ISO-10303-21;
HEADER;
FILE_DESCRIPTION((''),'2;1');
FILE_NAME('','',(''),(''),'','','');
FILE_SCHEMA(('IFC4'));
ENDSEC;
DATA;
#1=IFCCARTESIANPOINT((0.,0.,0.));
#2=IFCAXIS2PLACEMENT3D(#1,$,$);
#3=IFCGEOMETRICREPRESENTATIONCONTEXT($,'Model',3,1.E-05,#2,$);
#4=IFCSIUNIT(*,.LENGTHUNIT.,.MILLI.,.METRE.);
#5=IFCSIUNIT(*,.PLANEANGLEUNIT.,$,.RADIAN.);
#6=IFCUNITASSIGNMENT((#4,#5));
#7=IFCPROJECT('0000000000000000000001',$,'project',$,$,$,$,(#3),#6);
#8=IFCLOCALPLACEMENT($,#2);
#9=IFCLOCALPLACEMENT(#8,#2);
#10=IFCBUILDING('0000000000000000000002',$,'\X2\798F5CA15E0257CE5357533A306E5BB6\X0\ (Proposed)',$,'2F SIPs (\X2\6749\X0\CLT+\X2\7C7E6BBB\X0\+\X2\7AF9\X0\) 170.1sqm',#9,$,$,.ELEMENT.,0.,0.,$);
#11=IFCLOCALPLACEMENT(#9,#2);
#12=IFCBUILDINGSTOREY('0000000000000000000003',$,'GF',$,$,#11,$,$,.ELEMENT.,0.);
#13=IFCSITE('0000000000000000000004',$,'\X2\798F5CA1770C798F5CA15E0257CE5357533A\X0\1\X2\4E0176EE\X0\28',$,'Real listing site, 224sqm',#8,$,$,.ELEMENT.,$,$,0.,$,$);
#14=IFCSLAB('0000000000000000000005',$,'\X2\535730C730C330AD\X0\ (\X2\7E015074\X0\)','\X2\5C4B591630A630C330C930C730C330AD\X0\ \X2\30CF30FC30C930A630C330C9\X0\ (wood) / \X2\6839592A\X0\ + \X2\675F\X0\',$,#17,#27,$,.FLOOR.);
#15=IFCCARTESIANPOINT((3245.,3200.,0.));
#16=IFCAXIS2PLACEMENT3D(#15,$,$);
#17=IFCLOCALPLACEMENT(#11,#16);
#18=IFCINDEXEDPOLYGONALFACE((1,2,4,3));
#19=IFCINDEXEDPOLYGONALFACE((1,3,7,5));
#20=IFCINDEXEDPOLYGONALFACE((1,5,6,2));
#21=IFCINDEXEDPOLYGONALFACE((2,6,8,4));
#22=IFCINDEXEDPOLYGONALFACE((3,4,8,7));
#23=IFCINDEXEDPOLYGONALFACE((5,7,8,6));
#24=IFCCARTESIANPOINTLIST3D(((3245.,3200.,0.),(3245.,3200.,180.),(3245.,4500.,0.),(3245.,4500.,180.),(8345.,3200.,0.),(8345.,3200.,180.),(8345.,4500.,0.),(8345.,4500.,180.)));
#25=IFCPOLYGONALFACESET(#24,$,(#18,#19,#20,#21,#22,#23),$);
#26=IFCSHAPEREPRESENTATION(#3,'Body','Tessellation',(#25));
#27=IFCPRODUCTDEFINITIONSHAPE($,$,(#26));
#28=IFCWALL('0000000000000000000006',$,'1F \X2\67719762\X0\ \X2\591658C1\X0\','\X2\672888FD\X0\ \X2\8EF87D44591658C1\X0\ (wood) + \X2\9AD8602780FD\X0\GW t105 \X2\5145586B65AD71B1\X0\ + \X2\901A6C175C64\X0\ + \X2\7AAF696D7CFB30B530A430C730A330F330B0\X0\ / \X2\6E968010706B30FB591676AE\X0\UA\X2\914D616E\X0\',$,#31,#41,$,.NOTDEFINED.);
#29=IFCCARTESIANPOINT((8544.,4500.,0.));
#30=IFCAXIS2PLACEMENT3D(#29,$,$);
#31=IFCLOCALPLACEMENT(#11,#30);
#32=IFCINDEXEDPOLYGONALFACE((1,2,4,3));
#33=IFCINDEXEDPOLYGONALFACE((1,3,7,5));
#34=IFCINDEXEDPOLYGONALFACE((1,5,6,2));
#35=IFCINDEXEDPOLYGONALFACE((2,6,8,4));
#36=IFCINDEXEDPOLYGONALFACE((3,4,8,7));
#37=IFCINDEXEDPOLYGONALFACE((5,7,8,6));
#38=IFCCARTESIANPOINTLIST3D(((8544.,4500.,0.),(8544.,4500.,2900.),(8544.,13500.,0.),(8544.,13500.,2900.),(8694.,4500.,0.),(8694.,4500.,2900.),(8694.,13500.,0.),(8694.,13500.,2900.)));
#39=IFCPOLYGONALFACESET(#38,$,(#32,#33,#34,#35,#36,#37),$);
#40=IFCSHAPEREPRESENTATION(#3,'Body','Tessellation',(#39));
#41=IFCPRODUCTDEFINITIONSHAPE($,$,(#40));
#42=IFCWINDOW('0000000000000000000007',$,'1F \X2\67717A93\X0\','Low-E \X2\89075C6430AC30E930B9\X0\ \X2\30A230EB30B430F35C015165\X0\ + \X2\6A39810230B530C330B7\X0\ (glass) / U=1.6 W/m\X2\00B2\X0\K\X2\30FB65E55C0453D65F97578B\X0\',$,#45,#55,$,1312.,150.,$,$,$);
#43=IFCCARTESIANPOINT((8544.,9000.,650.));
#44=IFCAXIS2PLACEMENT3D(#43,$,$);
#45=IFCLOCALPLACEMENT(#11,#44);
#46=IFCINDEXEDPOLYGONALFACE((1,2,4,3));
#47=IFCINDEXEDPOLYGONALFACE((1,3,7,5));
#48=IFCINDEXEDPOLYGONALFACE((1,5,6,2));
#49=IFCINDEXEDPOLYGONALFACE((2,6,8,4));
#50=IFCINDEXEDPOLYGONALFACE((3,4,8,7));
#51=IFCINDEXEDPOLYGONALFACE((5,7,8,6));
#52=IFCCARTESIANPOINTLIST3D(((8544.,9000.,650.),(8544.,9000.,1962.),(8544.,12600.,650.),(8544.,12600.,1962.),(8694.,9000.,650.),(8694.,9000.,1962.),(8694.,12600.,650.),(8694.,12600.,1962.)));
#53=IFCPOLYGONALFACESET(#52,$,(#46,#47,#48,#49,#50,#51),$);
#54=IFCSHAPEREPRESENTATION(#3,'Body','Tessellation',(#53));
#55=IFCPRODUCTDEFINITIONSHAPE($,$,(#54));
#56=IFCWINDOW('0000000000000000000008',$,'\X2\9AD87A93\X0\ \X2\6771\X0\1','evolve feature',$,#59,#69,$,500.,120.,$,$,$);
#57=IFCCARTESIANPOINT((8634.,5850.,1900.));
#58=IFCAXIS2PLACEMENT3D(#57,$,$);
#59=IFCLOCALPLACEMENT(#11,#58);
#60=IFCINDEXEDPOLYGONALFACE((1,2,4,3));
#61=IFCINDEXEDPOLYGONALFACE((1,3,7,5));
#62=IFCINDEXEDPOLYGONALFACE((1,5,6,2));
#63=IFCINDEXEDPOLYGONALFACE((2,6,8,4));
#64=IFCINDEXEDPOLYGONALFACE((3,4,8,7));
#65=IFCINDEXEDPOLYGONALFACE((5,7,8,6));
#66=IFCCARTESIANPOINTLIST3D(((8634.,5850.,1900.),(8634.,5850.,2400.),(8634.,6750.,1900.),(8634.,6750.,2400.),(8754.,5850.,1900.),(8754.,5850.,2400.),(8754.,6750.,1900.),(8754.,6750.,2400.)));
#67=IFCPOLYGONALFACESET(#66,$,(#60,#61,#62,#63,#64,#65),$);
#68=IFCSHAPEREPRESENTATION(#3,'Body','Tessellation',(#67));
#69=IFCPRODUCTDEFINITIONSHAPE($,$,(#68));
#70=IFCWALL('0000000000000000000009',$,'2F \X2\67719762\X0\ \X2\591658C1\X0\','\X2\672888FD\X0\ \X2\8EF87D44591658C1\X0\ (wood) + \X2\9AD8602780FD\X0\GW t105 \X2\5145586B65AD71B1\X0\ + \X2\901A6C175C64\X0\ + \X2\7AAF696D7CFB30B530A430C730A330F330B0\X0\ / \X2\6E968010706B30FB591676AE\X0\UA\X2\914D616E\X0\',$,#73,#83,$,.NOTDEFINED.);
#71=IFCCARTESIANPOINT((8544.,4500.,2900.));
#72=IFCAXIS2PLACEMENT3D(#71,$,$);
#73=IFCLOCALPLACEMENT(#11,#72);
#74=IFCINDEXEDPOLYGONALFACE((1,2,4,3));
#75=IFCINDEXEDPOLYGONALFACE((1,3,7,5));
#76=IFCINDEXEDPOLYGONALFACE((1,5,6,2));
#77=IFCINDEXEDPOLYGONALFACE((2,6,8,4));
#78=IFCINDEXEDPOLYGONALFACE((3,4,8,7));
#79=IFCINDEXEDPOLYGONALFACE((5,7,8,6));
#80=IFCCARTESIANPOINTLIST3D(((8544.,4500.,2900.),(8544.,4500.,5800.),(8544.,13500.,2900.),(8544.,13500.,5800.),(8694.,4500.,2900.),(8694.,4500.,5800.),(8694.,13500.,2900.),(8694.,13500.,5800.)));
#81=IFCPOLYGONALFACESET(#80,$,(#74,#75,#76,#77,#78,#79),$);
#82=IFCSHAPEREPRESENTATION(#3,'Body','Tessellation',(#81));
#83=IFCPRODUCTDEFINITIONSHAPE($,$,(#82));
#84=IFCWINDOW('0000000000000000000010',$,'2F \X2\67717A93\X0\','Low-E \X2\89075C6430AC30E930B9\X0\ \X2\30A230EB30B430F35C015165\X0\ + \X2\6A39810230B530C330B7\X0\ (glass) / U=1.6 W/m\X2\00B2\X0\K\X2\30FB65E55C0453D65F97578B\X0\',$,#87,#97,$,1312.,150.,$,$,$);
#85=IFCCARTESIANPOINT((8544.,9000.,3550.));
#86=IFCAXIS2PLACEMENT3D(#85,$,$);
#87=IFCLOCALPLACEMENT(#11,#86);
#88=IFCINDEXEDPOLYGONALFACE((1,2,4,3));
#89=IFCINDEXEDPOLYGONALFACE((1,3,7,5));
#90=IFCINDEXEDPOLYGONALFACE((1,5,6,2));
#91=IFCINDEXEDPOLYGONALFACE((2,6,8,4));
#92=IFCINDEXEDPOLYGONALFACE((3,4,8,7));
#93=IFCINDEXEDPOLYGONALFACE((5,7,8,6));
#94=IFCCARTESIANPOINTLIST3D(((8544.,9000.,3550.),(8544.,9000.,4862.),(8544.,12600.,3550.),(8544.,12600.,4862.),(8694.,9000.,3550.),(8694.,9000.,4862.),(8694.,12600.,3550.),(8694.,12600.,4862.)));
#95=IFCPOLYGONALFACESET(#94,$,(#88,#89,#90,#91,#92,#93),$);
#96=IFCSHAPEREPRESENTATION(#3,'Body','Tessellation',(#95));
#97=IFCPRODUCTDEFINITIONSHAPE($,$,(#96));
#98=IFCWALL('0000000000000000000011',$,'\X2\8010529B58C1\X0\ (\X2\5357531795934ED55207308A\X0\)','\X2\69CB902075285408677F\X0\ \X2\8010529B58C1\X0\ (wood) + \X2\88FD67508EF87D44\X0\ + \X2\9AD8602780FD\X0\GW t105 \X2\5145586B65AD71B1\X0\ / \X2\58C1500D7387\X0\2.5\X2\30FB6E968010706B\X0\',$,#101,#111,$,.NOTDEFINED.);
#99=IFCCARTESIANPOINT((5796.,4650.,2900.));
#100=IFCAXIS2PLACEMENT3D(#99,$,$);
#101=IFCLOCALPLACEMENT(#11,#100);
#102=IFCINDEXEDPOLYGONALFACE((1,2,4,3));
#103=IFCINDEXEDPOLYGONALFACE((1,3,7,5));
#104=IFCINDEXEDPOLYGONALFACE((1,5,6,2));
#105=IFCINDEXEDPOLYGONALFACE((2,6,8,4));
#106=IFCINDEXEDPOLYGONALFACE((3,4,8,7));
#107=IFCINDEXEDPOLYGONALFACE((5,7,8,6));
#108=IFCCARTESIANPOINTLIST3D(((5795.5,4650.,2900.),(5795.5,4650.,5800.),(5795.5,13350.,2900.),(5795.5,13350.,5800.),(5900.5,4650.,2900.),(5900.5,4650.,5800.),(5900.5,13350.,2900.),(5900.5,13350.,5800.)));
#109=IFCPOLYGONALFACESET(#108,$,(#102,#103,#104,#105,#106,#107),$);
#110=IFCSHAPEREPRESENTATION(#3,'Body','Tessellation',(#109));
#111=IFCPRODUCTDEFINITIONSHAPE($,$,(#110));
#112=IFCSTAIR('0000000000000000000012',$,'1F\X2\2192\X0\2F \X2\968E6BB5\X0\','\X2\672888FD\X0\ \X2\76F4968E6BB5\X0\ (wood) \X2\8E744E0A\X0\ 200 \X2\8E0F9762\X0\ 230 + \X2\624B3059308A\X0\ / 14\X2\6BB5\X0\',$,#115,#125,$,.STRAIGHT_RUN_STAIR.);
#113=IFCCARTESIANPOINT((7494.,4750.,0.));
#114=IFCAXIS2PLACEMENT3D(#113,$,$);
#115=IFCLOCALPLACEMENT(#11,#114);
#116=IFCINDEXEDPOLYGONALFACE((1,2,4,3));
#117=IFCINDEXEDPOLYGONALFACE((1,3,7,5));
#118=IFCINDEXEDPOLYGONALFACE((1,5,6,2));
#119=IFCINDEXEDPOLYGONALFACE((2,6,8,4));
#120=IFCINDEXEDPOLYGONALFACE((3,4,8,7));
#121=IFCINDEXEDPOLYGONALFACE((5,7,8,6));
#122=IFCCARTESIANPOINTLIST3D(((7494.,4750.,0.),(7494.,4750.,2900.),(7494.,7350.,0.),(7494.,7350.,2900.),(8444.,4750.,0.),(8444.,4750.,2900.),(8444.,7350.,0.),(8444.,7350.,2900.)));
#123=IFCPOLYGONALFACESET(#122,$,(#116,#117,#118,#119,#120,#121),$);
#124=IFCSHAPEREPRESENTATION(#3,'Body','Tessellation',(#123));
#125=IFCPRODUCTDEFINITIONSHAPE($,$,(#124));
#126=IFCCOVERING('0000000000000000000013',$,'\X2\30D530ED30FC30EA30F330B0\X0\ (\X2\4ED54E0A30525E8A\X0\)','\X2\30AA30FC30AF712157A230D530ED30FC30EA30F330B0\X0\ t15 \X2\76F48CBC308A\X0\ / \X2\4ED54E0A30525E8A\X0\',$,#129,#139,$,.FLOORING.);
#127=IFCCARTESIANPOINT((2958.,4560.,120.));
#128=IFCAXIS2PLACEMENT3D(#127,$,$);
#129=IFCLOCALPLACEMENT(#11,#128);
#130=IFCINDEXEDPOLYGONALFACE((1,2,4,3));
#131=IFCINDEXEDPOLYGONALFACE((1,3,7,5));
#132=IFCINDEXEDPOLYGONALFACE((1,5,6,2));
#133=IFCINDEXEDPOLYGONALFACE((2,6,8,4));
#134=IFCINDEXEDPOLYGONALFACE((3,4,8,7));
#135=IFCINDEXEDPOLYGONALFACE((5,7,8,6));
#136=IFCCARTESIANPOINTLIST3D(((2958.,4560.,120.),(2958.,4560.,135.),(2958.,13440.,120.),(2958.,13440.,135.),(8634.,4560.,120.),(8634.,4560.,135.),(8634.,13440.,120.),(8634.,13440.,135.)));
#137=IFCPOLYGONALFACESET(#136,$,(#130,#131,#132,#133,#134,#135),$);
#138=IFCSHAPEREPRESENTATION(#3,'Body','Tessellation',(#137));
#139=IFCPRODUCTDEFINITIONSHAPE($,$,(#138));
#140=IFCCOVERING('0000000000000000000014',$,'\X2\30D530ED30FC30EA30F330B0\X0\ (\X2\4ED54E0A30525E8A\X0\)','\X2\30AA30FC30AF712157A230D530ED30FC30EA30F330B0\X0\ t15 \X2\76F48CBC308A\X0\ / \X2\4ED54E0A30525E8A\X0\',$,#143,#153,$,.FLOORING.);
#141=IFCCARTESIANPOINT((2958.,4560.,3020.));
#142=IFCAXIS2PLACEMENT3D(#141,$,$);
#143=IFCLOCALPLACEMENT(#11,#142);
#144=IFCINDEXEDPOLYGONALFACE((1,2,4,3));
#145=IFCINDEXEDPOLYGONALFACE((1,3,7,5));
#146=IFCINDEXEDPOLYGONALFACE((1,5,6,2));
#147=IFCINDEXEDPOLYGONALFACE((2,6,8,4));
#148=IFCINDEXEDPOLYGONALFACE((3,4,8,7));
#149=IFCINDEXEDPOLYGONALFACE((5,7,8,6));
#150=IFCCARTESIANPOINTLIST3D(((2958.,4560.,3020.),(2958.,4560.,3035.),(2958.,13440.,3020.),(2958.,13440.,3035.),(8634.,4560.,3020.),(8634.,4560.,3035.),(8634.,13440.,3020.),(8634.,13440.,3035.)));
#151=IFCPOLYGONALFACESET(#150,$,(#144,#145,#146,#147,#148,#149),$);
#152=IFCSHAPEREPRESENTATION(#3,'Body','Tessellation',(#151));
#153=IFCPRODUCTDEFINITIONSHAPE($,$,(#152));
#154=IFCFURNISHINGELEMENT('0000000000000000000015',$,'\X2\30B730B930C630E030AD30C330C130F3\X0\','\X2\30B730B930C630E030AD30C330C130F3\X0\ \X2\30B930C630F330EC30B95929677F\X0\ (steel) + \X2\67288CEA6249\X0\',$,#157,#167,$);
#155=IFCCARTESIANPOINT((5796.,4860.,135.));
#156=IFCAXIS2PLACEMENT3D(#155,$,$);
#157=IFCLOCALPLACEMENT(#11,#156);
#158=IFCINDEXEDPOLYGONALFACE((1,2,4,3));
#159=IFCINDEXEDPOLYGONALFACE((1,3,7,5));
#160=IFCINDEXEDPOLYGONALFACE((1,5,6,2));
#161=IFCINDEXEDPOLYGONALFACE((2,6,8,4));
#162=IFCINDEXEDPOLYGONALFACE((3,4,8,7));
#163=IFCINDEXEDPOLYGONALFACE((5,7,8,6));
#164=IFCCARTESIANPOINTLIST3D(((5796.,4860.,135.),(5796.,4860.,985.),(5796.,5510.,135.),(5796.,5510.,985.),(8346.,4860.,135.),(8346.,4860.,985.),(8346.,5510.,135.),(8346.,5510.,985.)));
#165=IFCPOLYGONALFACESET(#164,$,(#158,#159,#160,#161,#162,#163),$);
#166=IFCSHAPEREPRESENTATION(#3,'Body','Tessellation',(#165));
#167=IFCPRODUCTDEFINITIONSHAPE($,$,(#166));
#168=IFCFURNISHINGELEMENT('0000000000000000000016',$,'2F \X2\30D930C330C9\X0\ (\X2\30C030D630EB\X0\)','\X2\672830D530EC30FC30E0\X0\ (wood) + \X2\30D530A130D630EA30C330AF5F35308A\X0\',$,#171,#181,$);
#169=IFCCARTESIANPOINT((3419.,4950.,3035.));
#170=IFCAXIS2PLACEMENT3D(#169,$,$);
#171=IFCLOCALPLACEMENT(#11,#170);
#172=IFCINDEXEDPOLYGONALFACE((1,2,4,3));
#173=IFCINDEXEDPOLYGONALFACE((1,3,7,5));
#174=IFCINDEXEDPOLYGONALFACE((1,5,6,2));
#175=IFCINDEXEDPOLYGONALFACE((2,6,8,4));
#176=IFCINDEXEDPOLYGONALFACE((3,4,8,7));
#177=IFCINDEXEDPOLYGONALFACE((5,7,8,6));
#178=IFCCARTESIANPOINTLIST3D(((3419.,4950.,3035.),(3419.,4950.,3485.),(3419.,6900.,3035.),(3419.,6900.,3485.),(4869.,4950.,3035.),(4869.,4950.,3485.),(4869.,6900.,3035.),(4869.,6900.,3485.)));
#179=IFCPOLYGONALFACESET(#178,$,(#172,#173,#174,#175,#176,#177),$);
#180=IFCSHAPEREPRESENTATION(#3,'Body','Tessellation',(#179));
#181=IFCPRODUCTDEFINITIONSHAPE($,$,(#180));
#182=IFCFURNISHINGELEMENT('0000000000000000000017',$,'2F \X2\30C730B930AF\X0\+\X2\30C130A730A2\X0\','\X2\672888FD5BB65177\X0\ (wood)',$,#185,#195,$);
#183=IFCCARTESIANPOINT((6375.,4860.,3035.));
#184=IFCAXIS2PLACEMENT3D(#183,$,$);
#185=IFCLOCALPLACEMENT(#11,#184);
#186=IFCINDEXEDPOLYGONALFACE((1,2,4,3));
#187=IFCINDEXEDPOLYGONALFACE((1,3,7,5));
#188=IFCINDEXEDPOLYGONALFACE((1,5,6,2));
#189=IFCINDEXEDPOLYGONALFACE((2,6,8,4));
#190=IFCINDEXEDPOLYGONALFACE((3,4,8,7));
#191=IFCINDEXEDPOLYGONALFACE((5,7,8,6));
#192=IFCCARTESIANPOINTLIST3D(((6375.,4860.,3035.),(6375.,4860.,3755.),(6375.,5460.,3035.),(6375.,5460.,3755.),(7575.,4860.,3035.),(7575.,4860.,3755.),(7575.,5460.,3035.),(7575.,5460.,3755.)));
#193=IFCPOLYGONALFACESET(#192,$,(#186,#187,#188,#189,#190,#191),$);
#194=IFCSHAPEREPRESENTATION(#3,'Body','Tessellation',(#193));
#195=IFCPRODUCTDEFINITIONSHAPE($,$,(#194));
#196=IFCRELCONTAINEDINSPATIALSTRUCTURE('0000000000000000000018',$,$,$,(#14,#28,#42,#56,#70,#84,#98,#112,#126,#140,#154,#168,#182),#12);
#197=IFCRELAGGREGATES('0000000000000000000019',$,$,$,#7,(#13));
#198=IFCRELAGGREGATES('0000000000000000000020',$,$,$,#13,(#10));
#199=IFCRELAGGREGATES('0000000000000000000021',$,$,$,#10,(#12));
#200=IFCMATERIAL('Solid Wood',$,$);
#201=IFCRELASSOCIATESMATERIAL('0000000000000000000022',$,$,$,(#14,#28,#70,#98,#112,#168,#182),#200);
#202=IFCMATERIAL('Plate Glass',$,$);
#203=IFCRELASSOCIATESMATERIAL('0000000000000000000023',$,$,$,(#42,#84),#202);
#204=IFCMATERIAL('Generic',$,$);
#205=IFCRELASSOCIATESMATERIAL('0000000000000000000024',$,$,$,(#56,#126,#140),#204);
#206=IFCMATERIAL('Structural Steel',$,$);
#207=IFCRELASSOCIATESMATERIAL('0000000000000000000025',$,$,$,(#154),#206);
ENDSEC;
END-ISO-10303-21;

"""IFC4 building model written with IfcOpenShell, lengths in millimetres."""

from ifc_helpers import new_model, si_unit, frame, frame_2d, origin, place, context, project, spatial, rectangle, extrude, material, element, fill, save


model = new_model("IFC4")

# Units and contexts
model_context = context("Model", 3, precision=1e-05, world=origin())
ifc_project = project(units=[si_unit("LENGTHUNIT", "METRE", prefix="MILLI"), si_unit("PLANEANGLEUNIT", "RADIAN")], contexts=[model_context])

# Site, building, storey
site_placement = place(None, origin())
site = spatial("IfcSite", under=ifc_project, at=site_placement, Name="福岡県福岡市城南区1丁目28", ObjectType="Real listing site, 224sqm", CompositionType="ELEMENT", RefElevation=0.0)
building_placement = place(site_placement, origin())
building = spatial("IfcBuilding", under=site, at=building_placement, Name="福岡市城南区の家 (Proposed)", ObjectType="2F SIPs (杉CLT+籾殻+竹) 170.1sqm", CompositionType="ELEMENT", ElevationOfRefHeight=0.0, ElevationOfTerrain=0.0)
storey_placement = place(building_placement, origin())
storey = spatial("IfcBuildingStorey", under=building, at=storey_placement, Name="GF", CompositionType="ELEMENT", Elevation=0.0)

# Slab
ifc_material_1 = material(Name="Solid Wood")
slab_placement = place(storey_placement, frame((3245.0, 3200.0, 0.0)))
element("IfcSlab", 1, at=slab_placement, inside=storey, material=ifc_material_1, Name="南デッキ (縁側)", Description="屋外ウッドデッキ ハードウッド (wood) / 根太 + 束", PredefinedType="FLOOR", context=model_context, shape_type="SweptSolid", body=[
    extrude(rectangle(XDim=5100.0, YDim=1300.0, at=frame_2d((2550.0, 650.0))), frame((3245.0, 3200.0, 0.0)), (0.0, 0.0, 1.0), 180.0),
])

# Wall, openings, windows
wall_1_placement = place(storey_placement, frame((8544.0, 4500.0, 0.0)))
wall_1 = element("IfcWall", 2, at=wall_1_placement, inside=storey, material=ifc_material_1, Name="1F 東面 外壁", Description="木製 軸組外壁 (wood) + 高性能GW t105 充填断熱 + 通気層 + 窯業系サイディング / 準耐火・外皮UA配慮", PredefinedType="NOTDEFINED", context=model_context, shape_type="SweptSolid", body=[
    extrude(rectangle(XDim=150.0, YDim=9000.0, at=frame_2d((75.0, 4500.0))), frame((8544.0, 4500.0, 0.0)), (0.0, 0.0, 1.0), 2900.0),
])
opening_1_placement = place(storey_placement, frame((8544.0, 9000.0, 650.0)))
opening_1 = element("IfcOpeningElement", 3, at=opening_1_placement, cuts=wall_1, PredefinedType="NOTDEFINED", context=model_context, shape_type="SweptSolid", body=[
    extrude(rectangle(XDim=150.0, YDim=3600.0, at=frame_2d((75.0, 1800.0))), frame((8544.0, 9000.0, 650.0)), (0.0, 0.0, 1.0), 1312.0),
])
opening_2_placement = place(storey_placement, frame((8634.0, 5850.0, 1900.0)))
opening_2 = element("IfcOpeningElement", 4, at=opening_2_placement, cuts=wall_1, PredefinedType="NOTDEFINED", context=model_context, shape_type="SweptSolid", body=[
    extrude(rectangle(XDim=120.0, YDim=900.0, at=frame_2d((60.0, 450.0))), frame((8634.0, 5850.0, 1900.0)), (0.0, 0.0, 1.0), 500.0),
])
ifc_material_2 = material(Name="Plate Glass")
window_1_placement = place(storey_placement, frame((8544.0, 9000.0, 650.0)))
window_1 = element("IfcWindow", 5, at=window_1_placement, inside=storey, material=ifc_material_2, Name="1F 東窓", Description="Low-E 複層ガラス アルゴン封入 + 樹脂サッシ (glass) / U=1.6 W/m²K・日射取得型", OverallHeight=1312.0, OverallWidth=150.0, context=model_context, shape_type="SweptSolid", body=[
    extrude(rectangle(XDim=150.0, YDim=3600.0, at=frame_2d((75.0, 1800.0))), frame((8544.0, 9000.0, 650.0)), (0.0, 0.0, 1.0), 1312.0),
])
fill(opening_1, window_1)
ifc_material_3 = material(Name="Generic")
window_2_placement = place(storey_placement, frame((8634.0, 5850.0, 1900.0)))
window_2 = element("IfcWindow", 6, at=window_2_placement, inside=storey, material=ifc_material_3, Name="高窓 東1", Description="evolve feature", OverallHeight=500.0, OverallWidth=120.0, context=model_context, shape_type="SweptSolid", body=[
    extrude(rectangle(XDim=120.0, YDim=900.0, at=frame_2d((60.0, 450.0))), frame((8634.0, 5850.0, 1900.0)), (0.0, 0.0, 1.0), 500.0),
])
fill(opening_2, window_2)

# Wall, opening, window
wall_2_placement = place(storey_placement, frame((8544.0, 4500.0, 2900.0)))
wall_2 = element("IfcWall", 7, at=wall_2_placement, inside=storey, material=ifc_material_1, Name="2F 東面 外壁", Description="木製 軸組外壁 (wood) + 高性能GW t105 充填断熱 + 通気層 + 窯業系サイディング / 準耐火・外皮UA配慮", PredefinedType="NOTDEFINED", context=model_context, shape_type="SweptSolid", body=[
    extrude(rectangle(XDim=150.0, YDim=9000.0, at=frame_2d((75.0, 4500.0))), frame((8544.0, 4500.0, 2900.0)), (0.0, 0.0, 1.0), 2900.0),
])
opening_3_placement = place(storey_placement, frame((8544.0, 9000.0, 3550.0)))
opening_3 = element("IfcOpeningElement", 8, at=opening_3_placement, cuts=wall_2, PredefinedType="NOTDEFINED", context=model_context, shape_type="SweptSolid", body=[
    extrude(rectangle(XDim=150.0, YDim=3600.0, at=frame_2d((75.0, 1800.0))), frame((8544.0, 9000.0, 3550.0)), (0.0, 0.0, 1.0), 1312.0),
])
window_3_placement = place(storey_placement, frame((8544.0, 9000.0, 3550.0)))
window_3 = element("IfcWindow", 9, at=window_3_placement, inside=storey, material=ifc_material_2, Name="2F 東窓", Description="Low-E 複層ガラス アルゴン封入 + 樹脂サッシ (glass) / U=1.6 W/m²K・日射取得型", OverallHeight=1312.0, OverallWidth=150.0, context=model_context, shape_type="SweptSolid", body=[
    extrude(rectangle(XDim=150.0, YDim=3600.0, at=frame_2d((75.0, 1800.0))), frame((8544.0, 9000.0, 3550.0)), (0.0, 0.0, 1.0), 1312.0),
])
fill(opening_3, window_3)

# Wall
wall_3_placement = place(storey_placement, frame((5796.0, 4650.0, 2900.0)))
element("IfcWall", 10, at=wall_3_placement, inside=storey, material=ifc_material_1, Name="耐力壁 (南北間仕切り)", Description="構造用合板 耐力壁 (wood) + 製材軸組 + 高性能GW t105 充填断熱 / 壁倍率2.5・準耐火", PredefinedType="NOTDEFINED", context=model_context, shape_type="SweptSolid", body=[
    extrude(rectangle(XDim=105.0, YDim=8700.0, at=frame_2d((52.0, 4350.0))), frame((5796.0, 4650.0, 2900.0)), (0.0, 0.0, 1.0), 2900.0),
])

# Stair
stair_placement = place(storey_placement, frame((7494.0, 4750.0, 0.0)))
element("IfcStair", 11, at=stair_placement, inside=storey, material=ifc_material_1, Name="1F→2F 階段", Description="木製 直階段 (wood) 蹴上 200 踏面 230 + 手すり / 14段", PredefinedType="STRAIGHT_RUN_STAIR", context=model_context, shape_type="SweptSolid", body=[
    extrude(rectangle(XDim=950.0, YDim=2600.0, at=frame_2d((475.0, 1300.0))), frame((7494.0, 4750.0, 0.0)), (0.0, 0.0, 1.0), 2900.0),
])

# Coverings
covering_1_placement = place(storey_placement, frame((2958.0, 4560.0, 120.0)))
element("IfcCovering", 12, at=covering_1_placement, inside=storey, material=ifc_material_3, Name="フローリング (仕上げ床)", Description="オーク無垢フローリング t15 直貼り / 仕上げ床", PredefinedType="FLOORING", context=model_context, shape_type="SweptSolid", body=[
    extrude(rectangle(XDim=5676.0, YDim=8880.0, at=frame_2d((2838.0, 4440.0))), frame((2958.0, 4560.0, 120.0)), (0.0, 0.0, 1.0), 15.0),
])
covering_2_placement = place(storey_placement, frame((2958.0, 4560.0, 3020.0)))
element("IfcCovering", 13, at=covering_2_placement, inside=storey, material=ifc_material_3, Name="フローリング (仕上げ床)", Description="オーク無垢フローリング t15 直貼り / 仕上げ床", PredefinedType="FLOORING", context=model_context, shape_type="SweptSolid", body=[
    extrude(rectangle(XDim=5676.0, YDim=8880.0, at=frame_2d((2838.0, 4440.0))), frame((2958.0, 4560.0, 3020.0)), (0.0, 0.0, 1.0), 15.0),
])

# Furnishing elements
ifc_material_4 = material(Name="Structural Steel")
furnishing_1_placement = place(storey_placement, frame((5796.0, 4860.0, 135.0)))
element("IfcFurnishingElement", 14, at=furnishing_1_placement, inside=storey, material=ifc_material_4, Name="システムキッチン", Description="システムキッチン ステンレス天板 (steel) + 木質扉", context=model_context, shape_type="SweptSolid", body=[
    extrude(rectangle(XDim=2550.0, YDim=650.0, at=frame_2d((1275.0, 325.0))), frame((5796.0, 4860.0, 135.0)), (0.0, 0.0, 1.0), 850.0),
])
furnishing_2_placement = place(storey_placement, frame((3419.0, 4950.0, 3035.0)))
element("IfcFurnishingElement", 15, at=furnishing_2_placement, inside=storey, material=ifc_material_1, Name="2F ベッド (ダブル)", Description="木フレーム (wood) + ファブリック張り", context=model_context, shape_type="SweptSolid", body=[
    extrude(rectangle(XDim=1450.0, YDim=1950.0, at=frame_2d((725.0, 975.0))), frame((3419.0, 4950.0, 3035.0)), (0.0, 0.0, 1.0), 450.0),
])
furnishing_3_placement = place(storey_placement, frame((6375.0, 4860.0, 3035.0)))
element("IfcFurnishingElement", 16, at=furnishing_3_placement, inside=storey, material=ifc_material_1, Name="2F デスク+チェア", Description="木製家具 (wood)", context=model_context, shape_type="SweptSolid", body=[
    extrude(rectangle(XDim=1200.0, YDim=600.0, at=frame_2d((600.0, 300.0))), frame((6375.0, 4860.0, 3035.0)), (0.0, 0.0, 1.0), 720.0),
])

save(model, "model.ifc")
